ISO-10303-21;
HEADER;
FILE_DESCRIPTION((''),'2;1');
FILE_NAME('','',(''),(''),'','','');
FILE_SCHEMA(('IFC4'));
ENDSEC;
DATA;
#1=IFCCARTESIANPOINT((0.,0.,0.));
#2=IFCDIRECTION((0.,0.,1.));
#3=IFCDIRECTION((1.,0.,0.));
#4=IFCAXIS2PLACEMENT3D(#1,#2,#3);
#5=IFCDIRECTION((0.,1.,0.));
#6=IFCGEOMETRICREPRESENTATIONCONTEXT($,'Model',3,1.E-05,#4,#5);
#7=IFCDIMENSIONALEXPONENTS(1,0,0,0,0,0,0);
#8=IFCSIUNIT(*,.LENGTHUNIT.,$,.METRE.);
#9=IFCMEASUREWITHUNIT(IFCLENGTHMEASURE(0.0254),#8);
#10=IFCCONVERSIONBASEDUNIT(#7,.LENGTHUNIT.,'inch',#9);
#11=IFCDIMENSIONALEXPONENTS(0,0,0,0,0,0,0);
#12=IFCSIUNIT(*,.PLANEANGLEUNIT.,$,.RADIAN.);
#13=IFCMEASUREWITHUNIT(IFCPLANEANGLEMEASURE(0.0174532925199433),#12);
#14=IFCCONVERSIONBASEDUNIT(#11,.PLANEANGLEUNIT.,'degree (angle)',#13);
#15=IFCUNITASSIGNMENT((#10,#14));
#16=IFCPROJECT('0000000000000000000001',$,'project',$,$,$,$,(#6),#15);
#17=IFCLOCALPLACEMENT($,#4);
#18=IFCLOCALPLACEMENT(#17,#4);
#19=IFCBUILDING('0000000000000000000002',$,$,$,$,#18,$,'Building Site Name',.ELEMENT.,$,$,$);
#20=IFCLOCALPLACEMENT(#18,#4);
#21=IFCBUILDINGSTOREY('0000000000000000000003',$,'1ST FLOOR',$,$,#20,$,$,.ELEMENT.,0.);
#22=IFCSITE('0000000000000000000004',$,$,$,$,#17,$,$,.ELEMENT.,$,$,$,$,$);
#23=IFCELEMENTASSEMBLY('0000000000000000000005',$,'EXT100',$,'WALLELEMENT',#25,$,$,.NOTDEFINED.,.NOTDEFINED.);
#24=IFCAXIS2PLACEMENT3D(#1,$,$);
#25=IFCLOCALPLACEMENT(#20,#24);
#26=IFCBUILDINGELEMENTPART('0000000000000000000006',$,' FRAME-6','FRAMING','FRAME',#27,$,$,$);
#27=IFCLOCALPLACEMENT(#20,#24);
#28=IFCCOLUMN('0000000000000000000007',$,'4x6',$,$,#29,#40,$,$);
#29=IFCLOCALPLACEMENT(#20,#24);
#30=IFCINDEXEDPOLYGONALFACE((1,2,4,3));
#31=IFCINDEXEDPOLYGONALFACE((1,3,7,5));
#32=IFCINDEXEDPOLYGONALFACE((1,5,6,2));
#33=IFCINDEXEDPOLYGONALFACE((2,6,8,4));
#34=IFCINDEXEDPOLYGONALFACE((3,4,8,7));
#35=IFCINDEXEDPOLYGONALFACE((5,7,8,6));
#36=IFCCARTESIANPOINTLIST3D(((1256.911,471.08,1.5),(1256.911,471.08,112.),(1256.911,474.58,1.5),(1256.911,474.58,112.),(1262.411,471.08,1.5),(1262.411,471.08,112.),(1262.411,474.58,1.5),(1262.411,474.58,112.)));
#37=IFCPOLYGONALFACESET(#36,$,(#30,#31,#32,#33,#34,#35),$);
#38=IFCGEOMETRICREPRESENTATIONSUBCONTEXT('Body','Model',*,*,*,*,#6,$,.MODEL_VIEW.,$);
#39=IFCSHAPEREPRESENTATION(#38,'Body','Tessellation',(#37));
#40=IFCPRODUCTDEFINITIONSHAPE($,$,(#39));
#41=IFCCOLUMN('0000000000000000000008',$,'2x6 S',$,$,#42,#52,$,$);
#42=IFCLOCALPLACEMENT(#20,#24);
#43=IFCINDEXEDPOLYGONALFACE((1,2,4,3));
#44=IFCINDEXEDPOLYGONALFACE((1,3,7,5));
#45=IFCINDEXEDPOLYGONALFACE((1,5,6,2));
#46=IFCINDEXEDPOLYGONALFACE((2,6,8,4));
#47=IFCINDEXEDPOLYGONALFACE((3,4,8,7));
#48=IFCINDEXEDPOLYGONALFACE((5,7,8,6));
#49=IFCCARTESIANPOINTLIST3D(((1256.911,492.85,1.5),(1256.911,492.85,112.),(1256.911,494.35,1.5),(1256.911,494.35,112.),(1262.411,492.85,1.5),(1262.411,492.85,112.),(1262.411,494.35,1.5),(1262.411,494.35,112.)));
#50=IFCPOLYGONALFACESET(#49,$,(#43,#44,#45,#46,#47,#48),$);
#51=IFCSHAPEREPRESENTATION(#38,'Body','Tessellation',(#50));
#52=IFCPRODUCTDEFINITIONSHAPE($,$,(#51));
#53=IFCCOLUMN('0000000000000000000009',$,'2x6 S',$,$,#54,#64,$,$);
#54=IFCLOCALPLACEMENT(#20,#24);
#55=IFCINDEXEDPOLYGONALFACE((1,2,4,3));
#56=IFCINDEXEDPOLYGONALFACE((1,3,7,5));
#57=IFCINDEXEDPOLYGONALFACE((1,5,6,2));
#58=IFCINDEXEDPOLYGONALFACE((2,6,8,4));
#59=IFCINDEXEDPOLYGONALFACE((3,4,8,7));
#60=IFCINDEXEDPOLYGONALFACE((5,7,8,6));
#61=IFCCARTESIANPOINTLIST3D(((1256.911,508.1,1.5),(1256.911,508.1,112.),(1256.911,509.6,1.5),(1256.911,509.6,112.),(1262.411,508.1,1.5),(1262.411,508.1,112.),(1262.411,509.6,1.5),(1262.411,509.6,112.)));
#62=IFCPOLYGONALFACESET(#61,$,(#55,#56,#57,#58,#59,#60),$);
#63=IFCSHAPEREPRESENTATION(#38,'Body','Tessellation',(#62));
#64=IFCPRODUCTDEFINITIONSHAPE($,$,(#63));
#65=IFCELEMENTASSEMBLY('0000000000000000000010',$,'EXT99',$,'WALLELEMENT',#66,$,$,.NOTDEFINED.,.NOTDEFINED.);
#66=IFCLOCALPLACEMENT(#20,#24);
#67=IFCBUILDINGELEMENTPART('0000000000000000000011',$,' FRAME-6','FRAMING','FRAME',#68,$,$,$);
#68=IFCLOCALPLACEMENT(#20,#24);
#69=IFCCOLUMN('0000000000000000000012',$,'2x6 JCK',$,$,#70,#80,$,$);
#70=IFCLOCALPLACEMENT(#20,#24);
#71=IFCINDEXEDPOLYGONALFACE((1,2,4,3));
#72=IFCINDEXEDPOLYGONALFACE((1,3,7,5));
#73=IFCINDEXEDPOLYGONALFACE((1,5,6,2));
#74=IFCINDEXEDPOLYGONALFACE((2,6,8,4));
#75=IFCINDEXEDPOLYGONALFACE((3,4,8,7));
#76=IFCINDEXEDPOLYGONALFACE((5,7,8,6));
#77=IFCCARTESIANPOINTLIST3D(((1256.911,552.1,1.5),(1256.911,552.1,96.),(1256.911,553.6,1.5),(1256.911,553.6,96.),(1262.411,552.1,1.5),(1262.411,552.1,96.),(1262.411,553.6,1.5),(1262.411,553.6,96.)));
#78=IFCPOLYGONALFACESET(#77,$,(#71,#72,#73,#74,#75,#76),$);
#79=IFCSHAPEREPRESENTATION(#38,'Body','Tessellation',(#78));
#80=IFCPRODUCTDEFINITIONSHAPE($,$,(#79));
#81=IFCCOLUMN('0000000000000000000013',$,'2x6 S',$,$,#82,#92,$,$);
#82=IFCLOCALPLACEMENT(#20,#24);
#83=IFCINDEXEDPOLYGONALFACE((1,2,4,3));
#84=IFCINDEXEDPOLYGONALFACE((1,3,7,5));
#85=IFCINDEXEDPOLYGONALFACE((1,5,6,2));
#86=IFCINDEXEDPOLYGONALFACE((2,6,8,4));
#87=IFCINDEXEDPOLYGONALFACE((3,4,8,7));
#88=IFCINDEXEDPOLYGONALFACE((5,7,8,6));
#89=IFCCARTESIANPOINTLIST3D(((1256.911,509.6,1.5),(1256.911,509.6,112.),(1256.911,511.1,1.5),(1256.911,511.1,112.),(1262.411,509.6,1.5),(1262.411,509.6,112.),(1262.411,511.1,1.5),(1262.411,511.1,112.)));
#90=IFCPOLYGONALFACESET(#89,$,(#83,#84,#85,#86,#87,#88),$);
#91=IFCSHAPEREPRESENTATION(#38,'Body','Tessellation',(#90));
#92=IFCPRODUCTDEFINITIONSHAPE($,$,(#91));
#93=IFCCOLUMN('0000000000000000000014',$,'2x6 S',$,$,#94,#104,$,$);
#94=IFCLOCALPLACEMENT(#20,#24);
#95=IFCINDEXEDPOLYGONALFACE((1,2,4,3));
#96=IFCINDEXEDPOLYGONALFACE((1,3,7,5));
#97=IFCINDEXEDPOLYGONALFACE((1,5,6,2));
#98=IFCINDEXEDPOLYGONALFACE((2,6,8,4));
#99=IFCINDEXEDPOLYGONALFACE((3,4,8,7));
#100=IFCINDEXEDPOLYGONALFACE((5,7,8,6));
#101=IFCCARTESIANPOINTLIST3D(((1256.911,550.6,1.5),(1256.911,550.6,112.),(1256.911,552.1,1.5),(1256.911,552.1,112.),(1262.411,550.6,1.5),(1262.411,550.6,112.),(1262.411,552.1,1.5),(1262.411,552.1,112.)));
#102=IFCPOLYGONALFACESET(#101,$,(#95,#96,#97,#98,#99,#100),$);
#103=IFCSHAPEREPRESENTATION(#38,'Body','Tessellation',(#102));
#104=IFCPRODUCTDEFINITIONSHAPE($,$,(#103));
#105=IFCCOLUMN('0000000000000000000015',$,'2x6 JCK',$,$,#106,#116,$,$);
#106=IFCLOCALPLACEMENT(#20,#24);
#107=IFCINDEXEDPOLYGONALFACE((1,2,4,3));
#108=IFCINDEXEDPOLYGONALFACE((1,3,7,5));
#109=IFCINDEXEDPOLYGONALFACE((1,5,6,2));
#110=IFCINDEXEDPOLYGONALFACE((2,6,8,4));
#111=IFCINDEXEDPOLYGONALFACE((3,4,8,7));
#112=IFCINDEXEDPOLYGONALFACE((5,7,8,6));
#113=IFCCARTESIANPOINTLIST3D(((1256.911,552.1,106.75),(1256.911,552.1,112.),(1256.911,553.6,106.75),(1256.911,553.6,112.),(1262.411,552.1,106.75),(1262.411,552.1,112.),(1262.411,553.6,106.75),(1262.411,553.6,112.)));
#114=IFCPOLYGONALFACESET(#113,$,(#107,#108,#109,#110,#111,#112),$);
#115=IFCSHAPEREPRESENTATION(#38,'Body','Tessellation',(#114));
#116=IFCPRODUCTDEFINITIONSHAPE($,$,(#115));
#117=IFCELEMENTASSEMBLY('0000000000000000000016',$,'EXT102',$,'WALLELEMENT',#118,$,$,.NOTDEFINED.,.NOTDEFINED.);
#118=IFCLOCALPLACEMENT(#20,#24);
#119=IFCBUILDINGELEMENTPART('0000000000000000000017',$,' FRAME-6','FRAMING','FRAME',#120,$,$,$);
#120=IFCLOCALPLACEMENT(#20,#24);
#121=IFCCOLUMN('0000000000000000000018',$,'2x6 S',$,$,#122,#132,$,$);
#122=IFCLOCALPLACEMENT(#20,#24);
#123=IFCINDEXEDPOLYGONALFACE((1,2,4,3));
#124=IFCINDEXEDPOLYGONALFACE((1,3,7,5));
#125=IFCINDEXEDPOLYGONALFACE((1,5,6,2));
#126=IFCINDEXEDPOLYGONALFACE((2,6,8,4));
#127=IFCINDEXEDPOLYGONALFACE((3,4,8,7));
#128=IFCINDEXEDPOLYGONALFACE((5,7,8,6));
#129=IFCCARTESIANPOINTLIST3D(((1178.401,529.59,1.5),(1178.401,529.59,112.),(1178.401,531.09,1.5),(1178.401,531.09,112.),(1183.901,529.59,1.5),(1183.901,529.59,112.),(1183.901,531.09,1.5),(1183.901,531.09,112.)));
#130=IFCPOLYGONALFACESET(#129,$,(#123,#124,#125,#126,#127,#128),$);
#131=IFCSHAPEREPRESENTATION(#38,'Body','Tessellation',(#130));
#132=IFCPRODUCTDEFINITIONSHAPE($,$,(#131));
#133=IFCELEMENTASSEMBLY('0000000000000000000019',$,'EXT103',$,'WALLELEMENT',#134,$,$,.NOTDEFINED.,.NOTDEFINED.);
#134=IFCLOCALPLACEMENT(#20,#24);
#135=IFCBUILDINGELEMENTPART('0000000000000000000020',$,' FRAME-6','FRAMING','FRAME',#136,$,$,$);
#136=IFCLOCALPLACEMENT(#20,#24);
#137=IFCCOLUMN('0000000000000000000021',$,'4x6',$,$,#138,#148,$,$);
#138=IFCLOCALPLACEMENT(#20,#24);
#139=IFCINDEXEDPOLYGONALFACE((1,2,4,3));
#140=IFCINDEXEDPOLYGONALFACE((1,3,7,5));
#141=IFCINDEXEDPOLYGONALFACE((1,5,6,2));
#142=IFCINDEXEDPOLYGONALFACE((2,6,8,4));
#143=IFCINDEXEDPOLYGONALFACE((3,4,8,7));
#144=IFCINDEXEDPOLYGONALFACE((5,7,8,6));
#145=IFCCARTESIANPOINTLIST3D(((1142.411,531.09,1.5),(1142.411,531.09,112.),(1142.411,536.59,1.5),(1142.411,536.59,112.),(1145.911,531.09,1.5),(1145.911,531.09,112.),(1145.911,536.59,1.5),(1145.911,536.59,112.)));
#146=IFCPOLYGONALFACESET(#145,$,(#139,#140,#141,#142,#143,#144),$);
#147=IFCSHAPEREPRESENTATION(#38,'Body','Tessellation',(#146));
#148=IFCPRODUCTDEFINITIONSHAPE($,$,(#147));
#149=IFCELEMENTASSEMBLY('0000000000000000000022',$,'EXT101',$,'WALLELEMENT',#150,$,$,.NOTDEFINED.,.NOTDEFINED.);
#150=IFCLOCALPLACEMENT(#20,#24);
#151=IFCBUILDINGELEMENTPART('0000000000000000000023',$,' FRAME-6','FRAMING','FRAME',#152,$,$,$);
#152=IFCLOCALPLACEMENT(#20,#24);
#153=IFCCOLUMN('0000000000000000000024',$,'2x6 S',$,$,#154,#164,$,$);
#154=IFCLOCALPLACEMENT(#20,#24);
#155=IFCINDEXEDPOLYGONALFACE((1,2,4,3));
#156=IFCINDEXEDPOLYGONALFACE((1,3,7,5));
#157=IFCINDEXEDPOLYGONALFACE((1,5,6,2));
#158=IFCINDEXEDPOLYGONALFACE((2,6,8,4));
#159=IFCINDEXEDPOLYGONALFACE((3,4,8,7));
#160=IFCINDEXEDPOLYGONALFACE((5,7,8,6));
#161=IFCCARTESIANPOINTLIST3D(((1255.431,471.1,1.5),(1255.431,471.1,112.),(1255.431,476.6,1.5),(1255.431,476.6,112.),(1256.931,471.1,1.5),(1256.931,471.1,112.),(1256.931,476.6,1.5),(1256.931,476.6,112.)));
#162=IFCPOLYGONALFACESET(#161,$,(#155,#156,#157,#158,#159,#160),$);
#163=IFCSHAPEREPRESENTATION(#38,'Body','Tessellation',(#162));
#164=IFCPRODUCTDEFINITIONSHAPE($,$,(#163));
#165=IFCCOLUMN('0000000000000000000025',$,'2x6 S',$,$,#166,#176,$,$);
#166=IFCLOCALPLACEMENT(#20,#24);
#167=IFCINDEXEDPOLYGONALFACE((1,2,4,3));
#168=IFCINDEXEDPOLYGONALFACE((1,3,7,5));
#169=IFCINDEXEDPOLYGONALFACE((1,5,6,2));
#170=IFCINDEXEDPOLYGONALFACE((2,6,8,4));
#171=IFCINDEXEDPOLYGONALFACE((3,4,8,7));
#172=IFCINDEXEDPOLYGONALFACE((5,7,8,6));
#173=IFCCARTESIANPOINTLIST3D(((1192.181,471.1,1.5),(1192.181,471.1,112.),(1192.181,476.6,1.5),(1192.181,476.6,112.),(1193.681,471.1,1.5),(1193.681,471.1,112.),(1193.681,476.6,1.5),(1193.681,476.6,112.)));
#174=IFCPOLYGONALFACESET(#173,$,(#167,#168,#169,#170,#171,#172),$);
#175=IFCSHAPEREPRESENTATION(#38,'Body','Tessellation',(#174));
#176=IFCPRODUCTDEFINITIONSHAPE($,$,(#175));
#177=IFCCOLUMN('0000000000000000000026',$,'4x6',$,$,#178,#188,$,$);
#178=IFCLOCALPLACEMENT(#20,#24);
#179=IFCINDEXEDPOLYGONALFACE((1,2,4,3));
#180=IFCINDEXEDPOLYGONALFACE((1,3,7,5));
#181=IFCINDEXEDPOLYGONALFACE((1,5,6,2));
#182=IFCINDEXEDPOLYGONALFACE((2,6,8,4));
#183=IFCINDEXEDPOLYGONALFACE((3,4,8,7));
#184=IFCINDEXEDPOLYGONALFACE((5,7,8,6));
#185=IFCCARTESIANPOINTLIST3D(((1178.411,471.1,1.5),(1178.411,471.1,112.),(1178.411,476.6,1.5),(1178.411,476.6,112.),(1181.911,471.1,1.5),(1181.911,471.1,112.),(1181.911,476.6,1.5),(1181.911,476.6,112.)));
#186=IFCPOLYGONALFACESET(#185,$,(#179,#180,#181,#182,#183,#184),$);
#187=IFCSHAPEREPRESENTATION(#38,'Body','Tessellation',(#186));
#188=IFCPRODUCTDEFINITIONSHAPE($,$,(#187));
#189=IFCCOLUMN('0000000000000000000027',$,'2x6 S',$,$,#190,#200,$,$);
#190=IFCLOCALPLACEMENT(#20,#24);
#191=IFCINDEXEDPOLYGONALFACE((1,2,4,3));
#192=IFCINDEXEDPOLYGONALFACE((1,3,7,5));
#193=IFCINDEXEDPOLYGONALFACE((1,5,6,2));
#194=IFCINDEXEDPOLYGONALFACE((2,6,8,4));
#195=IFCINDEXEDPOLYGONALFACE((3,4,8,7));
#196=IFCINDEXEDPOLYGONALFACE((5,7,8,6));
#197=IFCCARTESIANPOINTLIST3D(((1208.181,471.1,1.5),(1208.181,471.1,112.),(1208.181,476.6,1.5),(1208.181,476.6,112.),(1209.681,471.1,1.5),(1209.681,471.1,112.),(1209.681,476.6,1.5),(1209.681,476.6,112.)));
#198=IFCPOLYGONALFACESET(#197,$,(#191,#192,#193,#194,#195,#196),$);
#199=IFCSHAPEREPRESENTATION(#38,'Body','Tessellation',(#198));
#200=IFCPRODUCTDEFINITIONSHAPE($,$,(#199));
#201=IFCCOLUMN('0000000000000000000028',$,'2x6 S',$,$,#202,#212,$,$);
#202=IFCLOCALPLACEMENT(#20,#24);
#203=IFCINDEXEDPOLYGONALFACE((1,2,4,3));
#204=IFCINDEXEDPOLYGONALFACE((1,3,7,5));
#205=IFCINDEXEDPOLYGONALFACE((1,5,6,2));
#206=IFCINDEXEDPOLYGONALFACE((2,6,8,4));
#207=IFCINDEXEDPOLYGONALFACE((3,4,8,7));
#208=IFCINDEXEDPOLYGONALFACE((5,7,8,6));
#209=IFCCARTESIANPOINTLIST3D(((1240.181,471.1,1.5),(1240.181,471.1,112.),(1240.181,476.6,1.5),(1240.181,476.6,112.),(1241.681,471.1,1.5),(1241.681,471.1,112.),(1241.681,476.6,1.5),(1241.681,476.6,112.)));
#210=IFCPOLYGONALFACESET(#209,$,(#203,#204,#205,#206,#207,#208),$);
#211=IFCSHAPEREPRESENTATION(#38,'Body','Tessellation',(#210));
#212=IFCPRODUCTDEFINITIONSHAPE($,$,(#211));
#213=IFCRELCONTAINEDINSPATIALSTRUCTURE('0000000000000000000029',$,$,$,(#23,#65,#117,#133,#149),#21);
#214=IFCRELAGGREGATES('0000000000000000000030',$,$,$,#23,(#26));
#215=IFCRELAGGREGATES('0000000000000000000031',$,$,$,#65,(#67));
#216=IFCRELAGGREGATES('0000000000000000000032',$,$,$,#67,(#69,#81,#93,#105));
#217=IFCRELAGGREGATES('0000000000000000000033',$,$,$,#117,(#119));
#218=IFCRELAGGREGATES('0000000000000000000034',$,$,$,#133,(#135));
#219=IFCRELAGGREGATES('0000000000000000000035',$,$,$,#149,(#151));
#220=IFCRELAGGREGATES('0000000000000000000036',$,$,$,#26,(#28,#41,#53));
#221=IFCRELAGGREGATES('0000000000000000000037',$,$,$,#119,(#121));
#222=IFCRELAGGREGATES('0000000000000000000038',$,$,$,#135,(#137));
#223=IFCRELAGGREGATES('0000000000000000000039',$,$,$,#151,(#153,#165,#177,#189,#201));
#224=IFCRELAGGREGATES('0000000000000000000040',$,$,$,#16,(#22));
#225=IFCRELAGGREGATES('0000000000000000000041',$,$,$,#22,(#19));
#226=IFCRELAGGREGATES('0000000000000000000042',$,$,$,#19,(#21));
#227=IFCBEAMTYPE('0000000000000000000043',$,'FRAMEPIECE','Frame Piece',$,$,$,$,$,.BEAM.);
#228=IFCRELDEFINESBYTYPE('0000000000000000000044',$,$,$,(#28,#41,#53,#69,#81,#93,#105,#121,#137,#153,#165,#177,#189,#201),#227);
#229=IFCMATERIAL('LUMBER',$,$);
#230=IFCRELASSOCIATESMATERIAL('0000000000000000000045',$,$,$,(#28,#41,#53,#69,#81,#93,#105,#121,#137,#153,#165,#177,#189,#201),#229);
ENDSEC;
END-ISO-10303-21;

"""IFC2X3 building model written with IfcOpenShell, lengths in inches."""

from ifc_helpers import new_model, entity, si_unit, converted_unit, direction, frame, frame_2d, origin_with_axes, place, context, subcontext, project, spatial, polyline, segment, composite_curve, rectangle, outline, extrude, material, type_object, element, aggregate, save


model = new_model("IFC2X3")

# Units and contexts
model_context = context("Model", 3, precision=1e-05, world=origin_with_axes(), true_north=direction((0.0, 1.0, 0.0)))
body_context = subcontext(model_context, "Body", "Model", "MODEL_VIEW")
ifc_project = project(units=[converted_unit("LENGTHUNIT", "inch", entity("IfcLengthMeasure", 0.0254), si_unit("LENGTHUNIT", "METRE"), dimensions=[1, 0, 0, 0, 0, 0, 0]), converted_unit("PLANEANGLEUNIT", "degree (angle)", entity("IfcPlaneAngleMeasure", 0.0174532925199433), si_unit("PLANEANGLEUNIT", "RADIAN"), dimensions=[0, 0, 0, 0, 0, 0, 0])], contexts=[model_context])

# Site, building, storey
site_placement = place(None, origin_with_axes())
site = spatial("IfcSite", under=ifc_project, at=site_placement, CompositionType="ELEMENT")
building_placement = place(site_placement, origin_with_axes())
building = spatial("IfcBuilding", under=site, at=building_placement, LongName="Building Site Name", CompositionType="ELEMENT")
storey_placement = place(building_placement, origin_with_axes())
storey = spatial("IfcBuildingStorey", under=building, at=storey_placement, Name="1ST FLOOR", CompositionType="ELEMENT", Elevation=0.0)

# Element assemblies, building element parts, columns
assembly_1_placement = place(storey_placement, origin_with_axes())
assembly_1 = element("IfcElementAssembly", 1, at=assembly_1_placement, inside=storey, Name="EXT100", ObjectType="WALLELEMENT", AssemblyPlace="NOTDEFINED", PredefinedType="NOTDEFINED")
building_element_part_1 = element("IfcBuildingElementPart", 2, Name=" FRAME-6", Description="FRAMING", ObjectType="FRAME")
aggregate(assembly_1, [building_element_part_1])
ifc_material_1 = material(Name="LUMBER")
beam_type = type_object("IfcBeamType", Name="FRAMEPIECE", Description="Frame Piece", PredefinedType="BEAM")
column_1_placement = place(assembly_1_placement, frame((1259.661, 472.83, 1.5), z_axis=(0.0, 0.0, 1.0), x_axis=(0.0, 1.0, 0.0)))
column_1 = element("IfcColumn", 3, at=column_1_placement, type_object=beam_type, material=ifc_material_1, Name="4x6", context=body_context, shape_type="SweptSolid", body=[
    extrude(outline(composite_curve([segment(polyline([(-1.75, -2.75), (-1.75, 2.75), (1.75, 2.75), (1.75, -2.75), (-1.75, -2.75)]), True, "CONTINUOUS")], self_intersect=False)), frame((0.0, 0.0, 0.0), z_axis=(0.0, 0.0, 1.0), x_axis=(1.0, 0.0, 0.0)), (0.0, 0.0, 1.0), 110.5),
])
column_2_placement = place(assembly_1_placement, frame((1259.661, 493.6, 112.0), z_axis=(0.0, 0.0, -1.0), x_axis=(0.0, -1.0, 0.0)))
column_2 = element("IfcColumn", 4, at=column_2_placement, type_object=beam_type, material=ifc_material_1, Name="2x6 S", context=body_context, shape_type="SweptSolid", body=[
    extrude(rectangle(XDim=1.5, YDim=5.5, at=frame_2d((0.0, 0.0), x_axis=(-1.0, 0.0))), origin_with_axes(), (0.0, 0.0, 1.0), 110.5),
])
column_3_placement = place(assembly_1_placement, frame((1259.661, 508.85, 112.0), z_axis=(0.0, 0.0, -1.0), x_axis=(0.0, -1.0, 0.0)))
column_3 = element("IfcColumn", 5, at=column_3_placement, type_object=beam_type, material=ifc_material_1, Name="2x6 S", context=body_context, shape_type="SweptSolid", body=[
    extrude(rectangle(XDim=1.5, YDim=5.5, at=frame_2d((0.0, 0.0), x_axis=(-1.0, 0.0))), origin_with_axes(), (0.0, 0.0, 1.0), 110.5),
])
assembly_2_placement = place(storey_placement, origin_with_axes())
assembly_2 = element("IfcElementAssembly", 6, at=assembly_2_placement, inside=storey, Name="EXT99", ObjectType="WALLELEMENT", AssemblyPlace="NOTDEFINED", PredefinedType="NOTDEFINED")
building_element_part_2 = element("IfcBuildingElementPart", 7, Name=" FRAME-6", Description="FRAMING", ObjectType="FRAME")
aggregate(assembly_2, [building_element_part_2])
column_4_placement = place(assembly_2_placement, frame((1259.661, 552.85, 1.5), z_axis=(0.0, 0.0, 1.0), x_axis=(0.0, 1.0, 0.0)))
column_4 = element("IfcColumn", 8, at=column_4_placement, type_object=beam_type, material=ifc_material_1, Name="2x6 JCK", context=body_context, shape_type="SweptSolid", body=[
    extrude(rectangle(XDim=1.5, YDim=5.5, at=frame_2d((0.0, 0.0), x_axis=(-1.0, 0.0))), frame((0.0, 0.0, 0.0), z_axis=(0.0, 0.0, 1.0), x_axis=(1.0, 0.0, 0.0)), (0.0, 0.0, 1.0), 94.5),
])
column_5_placement = place(assembly_2_placement, frame((1259.661, 510.35, 1.5), z_axis=(0.0, 0.0, 1.0), x_axis=(0.0, 1.0, 0.0)))
column_5 = element("IfcColumn", 9, at=column_5_placement, type_object=beam_type, material=ifc_material_1, Name="2x6 S", context=body_context, shape_type="SweptSolid", body=[
    extrude(rectangle(XDim=1.5, YDim=5.5, at=frame_2d((0.0, 0.0), x_axis=(-1.0, 0.0))), frame((0.0, 0.0, 0.0), z_axis=(0.0, 0.0, 1.0), x_axis=(1.0, 0.0, 0.0)), (0.0, 0.0, 1.0), 110.5),
])
column_6_placement = place(assembly_2_placement, frame((1259.661, 551.35, 1.5), z_axis=(0.0, 0.0, 1.0), x_axis=(0.0, 1.0, 0.0)))
column_6 = element("IfcColumn", 10, at=column_6_placement, type_object=beam_type, material=ifc_material_1, Name="2x6 S", context=body_context, shape_type="SweptSolid", body=[
    extrude(rectangle(XDim=1.5, YDim=5.5, at=frame_2d((0.0, 0.0), x_axis=(-1.0, 0.0))), origin_with_axes(), (0.0, 0.0, 1.0), 110.5),
])
column_7_placement = place(assembly_2_placement, frame((1259.661, 552.85, 106.75), z_axis=(0.0, 0.0, 1.0), x_axis=(0.0, 1.0, 0.0)))
column_7 = element("IfcColumn", 11, at=column_7_placement, type_object=beam_type, material=ifc_material_1, Name="2x6 JCK", context=body_context, shape_type="SweptSolid", body=[
    extrude(rectangle(XDim=1.5, YDim=5.5, at=frame_2d((0.0, 0.0), x_axis=(-1.0, 0.0))), origin_with_axes(), (0.0, 0.0, 1.0), 5.25),
])
aggregate(building_element_part_2, [column_4, column_5, column_6, column_7])

# Element assemblies, building element parts, columns
assembly_3_placement = place(storey_placement, origin_with_axes())
assembly_3 = element("IfcElementAssembly", 12, at=assembly_3_placement, inside=storey, Name="EXT102", ObjectType="WALLELEMENT", AssemblyPlace="NOTDEFINED", PredefinedType="NOTDEFINED")
building_element_part_3 = element("IfcBuildingElementPart", 13, Name=" FRAME-6", Description="FRAMING", ObjectType="FRAME")
aggregate(assembly_3, [building_element_part_3])
column_8_placement = place(assembly_3_placement, frame((1181.151, 530.34, 1.5), z_axis=(0.0, 0.0, 1.0), x_axis=(0.0, -1.0, 0.0)))
column_8 = element("IfcColumn", 14, at=column_8_placement, type_object=beam_type, material=ifc_material_1, Name="2x6 S", context=body_context, shape_type="SweptSolid", body=[
    extrude(rectangle(XDim=1.5, YDim=5.5, at=frame_2d((0.0, 0.0), x_axis=(-1.0, 0.0))), frame((0.0, 0.0, 0.0), z_axis=(0.0, 0.0, 1.0), x_axis=(1.0, 0.0, 0.0)), (0.0, 0.0, 1.0), 110.5),
])
assembly_4_placement = place(storey_placement, origin_with_axes())
assembly_4 = element("IfcElementAssembly", 15, at=assembly_4_placement, inside=storey, Name="EXT103", ObjectType="WALLELEMENT", AssemblyPlace="NOTDEFINED", PredefinedType="NOTDEFINED")
building_element_part_4 = element("IfcBuildingElementPart", 16, Name=" FRAME-6", Description="FRAMING", ObjectType="FRAME")
aggregate(assembly_4, [building_element_part_4])
column_9_placement = place(assembly_4_placement, frame((1144.161, 533.84, 1.5), z_axis=(0.0, 0.0, 1.0), x_axis=(1.0, 0.0, 0.0)))
column_9 = element("IfcColumn", 17, at=column_9_placement, type_object=beam_type, material=ifc_material_1, Name="4x6", context=body_context, shape_type="SweptSolid", body=[
    extrude(outline(composite_curve([segment(polyline([(-1.75, -2.75), (-1.75, 2.75), (1.75, 2.75), (1.75, -2.75), (-1.75, -2.75)]), True, "CONTINUOUS")], self_intersect=False)), frame((0.0, 0.0, 0.0), z_axis=(0.0, 0.0, 1.0), x_axis=(1.0, 0.0, 0.0)), (0.0, 0.0, 1.0), 110.5),
])

# Element assembly, building element part, columns
assembly_5_placement = place(storey_placement, origin_with_axes())
assembly_5 = element("IfcElementAssembly", 18, at=assembly_5_placement, inside=storey, Name="EXT101", ObjectType="WALLELEMENT", AssemblyPlace="NOTDEFINED", PredefinedType="NOTDEFINED")
building_element_part_5 = element("IfcBuildingElementPart", 19, Name=" FRAME-6", Description="FRAMING", ObjectType="FRAME")
aggregate(assembly_5, [building_element_part_5])
column_10_placement = place(assembly_5_placement, frame((1256.181, 473.85, 112.0), z_axis=(0.0, 0.0, -1.0), x_axis=(-1.0, 0.0, 0.0)))
column_10 = element("IfcColumn", 20, at=column_10_placement, type_object=beam_type, material=ifc_material_1, Name="2x6 S", context=body_context, shape_type="SweptSolid", body=[
    extrude(rectangle(XDim=1.5, YDim=5.5, at=frame_2d((0.0, 0.0), x_axis=(-1.0, 0.0))), origin_with_axes(), (0.0, 0.0, 1.0), 110.5),
])
column_11_placement = place(assembly_5_placement, frame((1192.931, 473.85, 112.0), z_axis=(0.0, 0.0, -1.0), x_axis=(-1.0, 0.0, 0.0)))
column_11 = element("IfcColumn", 21, at=column_11_placement, type_object=beam_type, material=ifc_material_1, Name="2x6 S", context=body_context, shape_type="SweptSolid", body=[
    extrude(rectangle(XDim=1.5, YDim=5.5, at=frame_2d((0.0, 0.0), x_axis=(-1.0, 0.0))), origin_with_axes(), (0.0, 0.0, 1.0), 110.5),
])
column_12_placement = place(assembly_5_placement, frame((1180.161, 473.85, 1.5), z_axis=(0.0, 0.0, 1.0), x_axis=(1.0, 0.0, 0.0)))
column_12 = element("IfcColumn", 22, at=column_12_placement, type_object=beam_type, material=ifc_material_1, Name="4x6", context=body_context, shape_type="SweptSolid", body=[
    extrude(outline(composite_curve([segment(polyline([(-1.75, -2.75), (-1.75, 2.75), (1.75, 2.75), (1.75, -2.75), (-1.75, -2.75)]), True, "CONTINUOUS")], self_intersect=False)), origin_with_axes(), (0.0, 0.0, 1.0), 110.5),
])
column_13_placement = place(assembly_5_placement, frame((1208.931, 473.85, 112.0), z_axis=(0.0, 0.0, -1.0), x_axis=(-1.0, 0.0, 0.0)))
column_13 = element("IfcColumn", 23, at=column_13_placement, type_object=beam_type, material=ifc_material_1, Name="2x6 S", context=body_context, shape_type="SweptSolid", body=[
    extrude(rectangle(XDim=1.5, YDim=5.5, at=frame_2d((0.0, 0.0), x_axis=(-1.0, 0.0))), origin_with_axes(), (0.0, 0.0, 1.0), 110.5),
])
column_14_placement = place(assembly_5_placement, frame((1240.931, 473.85, 112.0), z_axis=(0.0, 0.0, -1.0), x_axis=(-1.0, 0.0, 0.0)))
column_14 = element("IfcColumn", 24, at=column_14_placement, type_object=beam_type, material=ifc_material_1, Name="2x6 S", context=body_context, shape_type="SweptSolid", body=[
    extrude(rectangle(XDim=1.5, YDim=5.5, at=frame_2d((0.0, 0.0), x_axis=(-1.0, 0.0))), origin_with_axes(), (0.0, 0.0, 1.0), 110.5),
])

aggregate(building_element_part_1, [column_1, column_2, column_3])
aggregate(building_element_part_3, [column_8])
aggregate(building_element_part_4, [column_9])

aggregate(building_element_part_5, [column_10, column_11, column_12, column_13, column_14])

save(model, "model.ifc")
